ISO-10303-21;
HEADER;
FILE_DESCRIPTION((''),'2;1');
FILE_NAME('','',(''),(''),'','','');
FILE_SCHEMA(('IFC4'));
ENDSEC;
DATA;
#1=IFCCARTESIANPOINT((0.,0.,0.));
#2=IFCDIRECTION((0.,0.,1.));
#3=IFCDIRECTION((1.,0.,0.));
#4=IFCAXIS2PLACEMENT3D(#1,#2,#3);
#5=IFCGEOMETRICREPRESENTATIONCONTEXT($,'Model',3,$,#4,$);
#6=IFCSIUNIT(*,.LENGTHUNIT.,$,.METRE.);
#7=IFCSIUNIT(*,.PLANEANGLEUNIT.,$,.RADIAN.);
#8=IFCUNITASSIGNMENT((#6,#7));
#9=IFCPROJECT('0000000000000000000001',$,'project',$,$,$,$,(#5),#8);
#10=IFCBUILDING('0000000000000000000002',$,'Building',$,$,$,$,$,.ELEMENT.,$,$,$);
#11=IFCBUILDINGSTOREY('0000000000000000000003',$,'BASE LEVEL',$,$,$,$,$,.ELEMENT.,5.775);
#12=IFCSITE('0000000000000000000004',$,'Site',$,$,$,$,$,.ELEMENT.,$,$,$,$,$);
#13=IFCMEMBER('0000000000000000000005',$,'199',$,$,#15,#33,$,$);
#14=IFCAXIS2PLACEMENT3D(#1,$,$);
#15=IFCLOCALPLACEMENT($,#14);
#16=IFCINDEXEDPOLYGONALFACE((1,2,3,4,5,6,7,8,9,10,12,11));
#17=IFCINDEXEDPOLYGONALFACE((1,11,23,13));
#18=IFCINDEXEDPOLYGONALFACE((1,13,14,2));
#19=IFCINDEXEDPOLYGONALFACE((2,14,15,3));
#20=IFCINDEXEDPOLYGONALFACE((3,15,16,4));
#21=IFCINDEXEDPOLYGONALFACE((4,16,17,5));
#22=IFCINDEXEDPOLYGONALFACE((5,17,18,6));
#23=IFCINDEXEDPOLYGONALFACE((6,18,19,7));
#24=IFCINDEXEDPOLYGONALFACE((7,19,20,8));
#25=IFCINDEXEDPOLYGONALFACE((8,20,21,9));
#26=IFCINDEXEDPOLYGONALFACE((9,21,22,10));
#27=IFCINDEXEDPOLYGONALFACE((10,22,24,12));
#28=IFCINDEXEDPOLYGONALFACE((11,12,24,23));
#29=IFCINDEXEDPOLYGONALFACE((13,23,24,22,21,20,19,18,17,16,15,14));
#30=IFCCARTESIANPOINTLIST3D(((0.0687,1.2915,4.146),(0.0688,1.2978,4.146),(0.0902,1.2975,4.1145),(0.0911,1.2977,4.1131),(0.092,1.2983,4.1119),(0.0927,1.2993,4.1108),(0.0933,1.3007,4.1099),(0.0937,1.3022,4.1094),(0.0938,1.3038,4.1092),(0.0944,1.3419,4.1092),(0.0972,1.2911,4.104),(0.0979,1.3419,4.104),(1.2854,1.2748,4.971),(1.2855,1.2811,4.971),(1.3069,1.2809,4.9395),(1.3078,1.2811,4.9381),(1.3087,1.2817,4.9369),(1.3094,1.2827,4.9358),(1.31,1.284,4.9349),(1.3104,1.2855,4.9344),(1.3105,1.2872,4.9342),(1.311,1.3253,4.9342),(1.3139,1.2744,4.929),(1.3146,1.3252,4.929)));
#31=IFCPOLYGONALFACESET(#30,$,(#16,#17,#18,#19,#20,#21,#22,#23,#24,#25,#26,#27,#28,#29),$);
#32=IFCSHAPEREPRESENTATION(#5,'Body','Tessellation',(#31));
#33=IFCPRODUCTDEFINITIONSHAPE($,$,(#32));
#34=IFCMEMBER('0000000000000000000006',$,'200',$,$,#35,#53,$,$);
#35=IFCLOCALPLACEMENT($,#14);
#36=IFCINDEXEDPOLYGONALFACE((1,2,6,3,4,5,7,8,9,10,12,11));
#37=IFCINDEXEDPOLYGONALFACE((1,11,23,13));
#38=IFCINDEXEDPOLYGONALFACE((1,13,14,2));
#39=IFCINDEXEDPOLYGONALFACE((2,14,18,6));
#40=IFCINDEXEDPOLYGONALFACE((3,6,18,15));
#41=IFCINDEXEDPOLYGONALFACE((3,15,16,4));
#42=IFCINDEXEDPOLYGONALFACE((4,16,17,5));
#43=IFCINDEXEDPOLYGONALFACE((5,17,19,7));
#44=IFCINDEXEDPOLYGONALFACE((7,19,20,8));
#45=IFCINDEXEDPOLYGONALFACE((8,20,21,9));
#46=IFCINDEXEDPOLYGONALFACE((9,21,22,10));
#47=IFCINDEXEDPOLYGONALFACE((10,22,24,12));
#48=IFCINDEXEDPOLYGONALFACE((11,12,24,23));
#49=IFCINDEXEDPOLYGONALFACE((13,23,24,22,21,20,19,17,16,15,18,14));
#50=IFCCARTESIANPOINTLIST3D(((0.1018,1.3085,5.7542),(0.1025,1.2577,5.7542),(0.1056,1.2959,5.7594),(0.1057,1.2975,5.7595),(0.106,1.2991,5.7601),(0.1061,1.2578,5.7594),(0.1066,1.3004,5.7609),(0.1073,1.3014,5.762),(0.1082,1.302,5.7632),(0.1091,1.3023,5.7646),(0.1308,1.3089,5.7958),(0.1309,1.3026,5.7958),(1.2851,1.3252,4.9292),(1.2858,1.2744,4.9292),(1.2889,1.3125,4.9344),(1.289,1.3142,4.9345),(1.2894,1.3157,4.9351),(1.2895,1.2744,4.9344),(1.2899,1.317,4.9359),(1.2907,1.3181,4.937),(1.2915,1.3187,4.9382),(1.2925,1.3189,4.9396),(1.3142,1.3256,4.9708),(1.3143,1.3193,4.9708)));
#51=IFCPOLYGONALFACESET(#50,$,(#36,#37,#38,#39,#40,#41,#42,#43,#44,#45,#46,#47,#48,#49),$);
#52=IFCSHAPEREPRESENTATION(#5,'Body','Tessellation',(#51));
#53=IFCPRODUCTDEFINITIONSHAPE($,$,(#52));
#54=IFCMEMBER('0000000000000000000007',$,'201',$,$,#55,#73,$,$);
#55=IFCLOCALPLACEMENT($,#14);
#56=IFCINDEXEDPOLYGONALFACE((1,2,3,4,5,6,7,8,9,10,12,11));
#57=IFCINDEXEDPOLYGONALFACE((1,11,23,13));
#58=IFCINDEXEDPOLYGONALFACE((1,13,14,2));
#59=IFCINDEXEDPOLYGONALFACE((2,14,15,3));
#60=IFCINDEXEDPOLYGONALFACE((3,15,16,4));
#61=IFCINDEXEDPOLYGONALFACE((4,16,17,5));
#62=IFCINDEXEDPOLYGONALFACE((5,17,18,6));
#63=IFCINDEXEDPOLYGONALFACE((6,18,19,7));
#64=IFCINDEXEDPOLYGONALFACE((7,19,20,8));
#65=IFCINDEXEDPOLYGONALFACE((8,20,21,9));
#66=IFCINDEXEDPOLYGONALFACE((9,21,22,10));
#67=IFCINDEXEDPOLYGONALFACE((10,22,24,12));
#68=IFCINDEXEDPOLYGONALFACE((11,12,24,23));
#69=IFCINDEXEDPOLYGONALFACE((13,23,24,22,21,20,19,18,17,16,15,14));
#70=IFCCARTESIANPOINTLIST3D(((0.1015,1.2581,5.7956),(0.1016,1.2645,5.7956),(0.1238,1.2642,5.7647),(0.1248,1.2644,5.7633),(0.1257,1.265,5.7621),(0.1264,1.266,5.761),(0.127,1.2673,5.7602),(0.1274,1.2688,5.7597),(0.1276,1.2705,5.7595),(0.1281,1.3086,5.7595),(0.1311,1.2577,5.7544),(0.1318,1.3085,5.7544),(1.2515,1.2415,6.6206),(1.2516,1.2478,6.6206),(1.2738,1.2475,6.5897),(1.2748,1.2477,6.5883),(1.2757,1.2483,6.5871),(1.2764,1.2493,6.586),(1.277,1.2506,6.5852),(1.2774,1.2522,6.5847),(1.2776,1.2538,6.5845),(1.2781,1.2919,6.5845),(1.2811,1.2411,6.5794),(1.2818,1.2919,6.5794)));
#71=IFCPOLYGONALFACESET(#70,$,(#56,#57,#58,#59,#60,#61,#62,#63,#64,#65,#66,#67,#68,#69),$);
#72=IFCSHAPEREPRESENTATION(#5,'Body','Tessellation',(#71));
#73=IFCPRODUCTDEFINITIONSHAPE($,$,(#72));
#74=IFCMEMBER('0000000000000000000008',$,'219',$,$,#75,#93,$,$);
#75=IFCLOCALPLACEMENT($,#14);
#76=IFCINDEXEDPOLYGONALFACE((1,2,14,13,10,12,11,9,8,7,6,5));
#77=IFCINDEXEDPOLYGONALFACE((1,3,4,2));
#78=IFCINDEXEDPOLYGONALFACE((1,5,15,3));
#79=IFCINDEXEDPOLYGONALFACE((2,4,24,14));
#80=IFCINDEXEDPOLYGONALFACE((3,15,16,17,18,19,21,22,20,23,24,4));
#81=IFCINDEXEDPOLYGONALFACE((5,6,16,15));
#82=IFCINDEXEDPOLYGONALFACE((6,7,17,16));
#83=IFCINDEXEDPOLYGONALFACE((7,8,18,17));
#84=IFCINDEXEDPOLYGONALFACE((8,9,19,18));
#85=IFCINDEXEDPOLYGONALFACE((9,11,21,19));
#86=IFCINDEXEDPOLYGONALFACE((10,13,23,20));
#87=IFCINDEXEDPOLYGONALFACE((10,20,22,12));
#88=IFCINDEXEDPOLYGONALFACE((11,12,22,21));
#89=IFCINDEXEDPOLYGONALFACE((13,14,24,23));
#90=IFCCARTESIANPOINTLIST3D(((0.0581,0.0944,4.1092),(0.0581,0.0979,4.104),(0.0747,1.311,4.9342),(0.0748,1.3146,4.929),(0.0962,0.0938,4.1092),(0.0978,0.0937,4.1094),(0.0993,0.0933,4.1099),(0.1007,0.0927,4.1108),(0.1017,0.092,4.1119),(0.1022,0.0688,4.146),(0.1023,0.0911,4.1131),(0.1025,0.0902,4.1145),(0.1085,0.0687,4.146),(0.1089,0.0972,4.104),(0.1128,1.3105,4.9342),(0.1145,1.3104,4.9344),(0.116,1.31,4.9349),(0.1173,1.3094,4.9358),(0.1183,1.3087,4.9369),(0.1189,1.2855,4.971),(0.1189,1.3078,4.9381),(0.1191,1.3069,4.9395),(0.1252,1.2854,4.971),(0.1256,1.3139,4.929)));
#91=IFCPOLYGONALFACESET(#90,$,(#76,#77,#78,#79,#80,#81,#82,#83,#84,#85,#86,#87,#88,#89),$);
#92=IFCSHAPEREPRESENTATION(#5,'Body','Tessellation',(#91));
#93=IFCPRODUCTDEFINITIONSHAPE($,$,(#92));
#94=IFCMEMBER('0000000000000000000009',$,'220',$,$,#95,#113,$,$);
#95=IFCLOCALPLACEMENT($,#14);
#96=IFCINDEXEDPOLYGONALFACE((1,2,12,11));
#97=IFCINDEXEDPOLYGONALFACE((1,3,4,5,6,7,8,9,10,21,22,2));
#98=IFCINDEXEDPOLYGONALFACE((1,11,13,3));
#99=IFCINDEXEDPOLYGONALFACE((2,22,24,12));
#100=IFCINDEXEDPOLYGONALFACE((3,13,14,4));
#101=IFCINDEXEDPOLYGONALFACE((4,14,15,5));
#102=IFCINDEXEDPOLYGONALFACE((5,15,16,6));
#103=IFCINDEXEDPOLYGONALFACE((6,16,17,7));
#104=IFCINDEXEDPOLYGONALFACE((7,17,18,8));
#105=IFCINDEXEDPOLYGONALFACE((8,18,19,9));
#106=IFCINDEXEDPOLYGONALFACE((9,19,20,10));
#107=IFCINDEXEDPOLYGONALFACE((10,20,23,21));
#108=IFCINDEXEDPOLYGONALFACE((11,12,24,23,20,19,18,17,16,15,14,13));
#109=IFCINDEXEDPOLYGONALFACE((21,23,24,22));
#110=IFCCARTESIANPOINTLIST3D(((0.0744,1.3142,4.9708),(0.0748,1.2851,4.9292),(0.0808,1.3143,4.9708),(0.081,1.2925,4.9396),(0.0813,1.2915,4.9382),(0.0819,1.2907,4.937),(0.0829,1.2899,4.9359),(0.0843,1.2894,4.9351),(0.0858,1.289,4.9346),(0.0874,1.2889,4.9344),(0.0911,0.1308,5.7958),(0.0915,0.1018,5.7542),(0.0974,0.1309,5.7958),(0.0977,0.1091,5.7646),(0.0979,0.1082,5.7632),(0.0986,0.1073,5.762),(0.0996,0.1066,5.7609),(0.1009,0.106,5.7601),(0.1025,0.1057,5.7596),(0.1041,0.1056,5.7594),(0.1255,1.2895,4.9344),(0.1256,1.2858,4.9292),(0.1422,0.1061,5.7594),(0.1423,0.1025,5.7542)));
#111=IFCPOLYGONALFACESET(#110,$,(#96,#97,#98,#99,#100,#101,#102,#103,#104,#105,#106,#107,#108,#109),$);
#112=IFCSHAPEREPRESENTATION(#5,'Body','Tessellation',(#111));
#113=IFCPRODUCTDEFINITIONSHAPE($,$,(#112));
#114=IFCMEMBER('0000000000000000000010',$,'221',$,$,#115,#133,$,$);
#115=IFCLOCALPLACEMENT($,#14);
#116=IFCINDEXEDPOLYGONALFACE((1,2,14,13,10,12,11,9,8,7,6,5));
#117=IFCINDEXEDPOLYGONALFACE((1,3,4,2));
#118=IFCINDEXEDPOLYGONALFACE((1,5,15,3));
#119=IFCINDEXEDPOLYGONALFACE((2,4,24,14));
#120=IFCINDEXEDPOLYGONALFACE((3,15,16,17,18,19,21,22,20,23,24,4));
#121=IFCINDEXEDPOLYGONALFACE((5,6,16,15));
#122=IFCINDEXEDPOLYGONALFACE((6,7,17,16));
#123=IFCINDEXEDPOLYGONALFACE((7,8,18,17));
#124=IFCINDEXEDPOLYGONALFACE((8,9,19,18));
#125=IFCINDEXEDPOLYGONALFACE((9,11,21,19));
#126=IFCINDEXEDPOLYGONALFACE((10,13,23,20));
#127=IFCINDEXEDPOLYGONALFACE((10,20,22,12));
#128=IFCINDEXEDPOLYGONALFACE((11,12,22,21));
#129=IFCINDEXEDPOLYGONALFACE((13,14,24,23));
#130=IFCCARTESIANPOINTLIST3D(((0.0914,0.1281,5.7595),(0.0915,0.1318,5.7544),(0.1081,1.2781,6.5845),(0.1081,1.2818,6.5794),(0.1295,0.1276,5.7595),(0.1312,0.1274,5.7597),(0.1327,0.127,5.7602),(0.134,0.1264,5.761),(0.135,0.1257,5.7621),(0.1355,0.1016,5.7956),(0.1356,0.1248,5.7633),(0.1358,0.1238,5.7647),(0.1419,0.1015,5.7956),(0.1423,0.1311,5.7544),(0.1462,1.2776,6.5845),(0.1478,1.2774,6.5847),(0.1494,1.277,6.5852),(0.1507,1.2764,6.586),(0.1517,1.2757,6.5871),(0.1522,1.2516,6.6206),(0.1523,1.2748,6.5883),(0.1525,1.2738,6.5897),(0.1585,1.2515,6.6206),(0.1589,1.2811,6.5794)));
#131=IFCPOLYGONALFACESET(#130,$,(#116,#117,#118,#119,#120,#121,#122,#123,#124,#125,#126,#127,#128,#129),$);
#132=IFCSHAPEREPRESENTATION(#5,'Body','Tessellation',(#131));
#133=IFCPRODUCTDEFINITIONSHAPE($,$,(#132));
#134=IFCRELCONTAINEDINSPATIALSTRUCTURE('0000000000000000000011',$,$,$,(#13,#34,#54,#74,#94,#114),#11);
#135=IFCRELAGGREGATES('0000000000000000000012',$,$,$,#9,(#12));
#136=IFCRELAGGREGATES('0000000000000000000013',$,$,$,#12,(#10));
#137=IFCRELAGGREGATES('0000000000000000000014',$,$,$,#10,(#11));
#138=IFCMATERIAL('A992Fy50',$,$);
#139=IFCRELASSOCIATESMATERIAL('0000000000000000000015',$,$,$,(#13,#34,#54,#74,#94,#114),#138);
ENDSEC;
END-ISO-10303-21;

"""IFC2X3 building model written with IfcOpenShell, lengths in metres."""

from ifc_helpers import new_model, si_unit, frame, origin_with_axes, origin_2d_with_axis, place, context, project, spatial, l_section, extrude, material, element, save


model = new_model("IFC2X3")

# Units and contexts
model_context = context("Model", 3, world=origin_with_axes())
ifc_project = project(units=[si_unit("LENGTHUNIT", "METRE"), si_unit("PLANEANGLEUNIT", "RADIAN")], contexts=[model_context])

# Site, building, storey
site = spatial("IfcSite", under=ifc_project, Name="Site", CompositionType="ELEMENT")
building = spatial("IfcBuilding", under=site, Name="Building", CompositionType="ELEMENT")
storey = spatial("IfcBuildingStorey", under=building, Name="BASE LEVEL", CompositionType="ELEMENT", Elevation=5.775)

# Members
ifc_material = material(Name="A992Fy50")
member_1_placement = place(None, frame((0.0833, 1.3167, 4.125), z_axis=(0.827611, -0.011337, 0.561188), x_axis=(0.013697, 0.999906, 0.0)))
element("IfcMember", 1, at=member_1_placement, inside=storey, material=ifc_material, Name="199", context=model_context, shape_type="SweptSolid", body=[
    extrude(l_section(Depth=0.0508, Width=0.0508, Thickness=0.0063, FilletRadius=0.0063, at=origin_2d_with_axis()), origin_with_axes(), (0.0, 0.0, 1.0), 1.4701),
])
member_2_placement = place(None, frame((1.3, 1.3, 4.95), z_axis=(-0.820261, -0.011553, 0.571872), x_axis=(0.014083, -0.999901, 0.0)))
element("IfcMember", 2, at=member_2_placement, inside=storey, material=ifc_material, Name="200", context=model_context, shape_type="SweptSolid", body=[
    extrude(l_section(Depth=0.0508, Width=0.0508, Thickness=0.0063, FilletRadius=0.0063, at=origin_2d_with_axis()), origin_with_axes(), (0.0, 0.0, 1.0), 1.4426),
])
member_3_placement = place(None, frame((0.1167, 1.2833, 5.775), z_axis=(0.812482, -0.011775, 0.582867), x_axis=(0.013697, 0.999906, 0.0)))
element("IfcMember", 3, at=member_3_placement, inside=storey, material=ifc_material, Name="201", context=model_context, shape_type="SweptSolid", body=[
    extrude(l_section(Depth=0.0508, Width=0.0508, Thickness=0.0063, FilletRadius=0.0063, at=origin_2d_with_axis()), origin_with_axes(), (0.0, 0.0, 1.0), 1.4154),
])
member_4_placement = place(None, frame((0.0833, 0.0833, 4.125), z_axis=(0.011337, 0.827611, 0.561188), x_axis=(-0.999906, 0.013697, 0.0)))
element("IfcMember", 4, at=member_4_placement, inside=storey, material=ifc_material, Name="219", context=model_context, shape_type="SweptSolid", body=[
    extrude(l_section(Depth=0.0508, Width=0.0508, Thickness=0.0063, FilletRadius=0.0063, at=origin_2d_with_axis()), origin_with_axes(), (0.0, 0.0, 1.0), 1.4701),
])
member_5_placement = place(None, frame((0.1, 1.3, 4.95), z_axis=(0.011553, -0.820261, 0.571872), x_axis=(0.999911, 0.013332, 0.0)))
element("IfcMember", 5, at=member_5_placement, inside=storey, material=ifc_material, Name="220", context=model_context, shape_type="SweptSolid", body=[
    extrude(l_section(Depth=0.0508, Width=0.0508, Thickness=0.0063, FilletRadius=0.0063, at=origin_2d_with_axis()), origin_with_axes(), (0.0, 0.0, 1.0), 1.4426),
])
member_6_placement = place(None, frame((0.1167, 0.1167, 5.775), z_axis=(0.011775, 0.812482, 0.582867), x_axis=(-0.999906, 0.013697, 0.0)))
element("IfcMember", 6, at=member_6_placement, inside=storey, material=ifc_material, Name="221", context=model_context, shape_type="SweptSolid", body=[
    extrude(l_section(Depth=0.0508, Width=0.0508, Thickness=0.0063, FilletRadius=0.0063, at=origin_2d_with_axis()), origin_with_axes(), (0.0, 0.0, 1.0), 1.4154),
])

save(model, "model.ifc")
